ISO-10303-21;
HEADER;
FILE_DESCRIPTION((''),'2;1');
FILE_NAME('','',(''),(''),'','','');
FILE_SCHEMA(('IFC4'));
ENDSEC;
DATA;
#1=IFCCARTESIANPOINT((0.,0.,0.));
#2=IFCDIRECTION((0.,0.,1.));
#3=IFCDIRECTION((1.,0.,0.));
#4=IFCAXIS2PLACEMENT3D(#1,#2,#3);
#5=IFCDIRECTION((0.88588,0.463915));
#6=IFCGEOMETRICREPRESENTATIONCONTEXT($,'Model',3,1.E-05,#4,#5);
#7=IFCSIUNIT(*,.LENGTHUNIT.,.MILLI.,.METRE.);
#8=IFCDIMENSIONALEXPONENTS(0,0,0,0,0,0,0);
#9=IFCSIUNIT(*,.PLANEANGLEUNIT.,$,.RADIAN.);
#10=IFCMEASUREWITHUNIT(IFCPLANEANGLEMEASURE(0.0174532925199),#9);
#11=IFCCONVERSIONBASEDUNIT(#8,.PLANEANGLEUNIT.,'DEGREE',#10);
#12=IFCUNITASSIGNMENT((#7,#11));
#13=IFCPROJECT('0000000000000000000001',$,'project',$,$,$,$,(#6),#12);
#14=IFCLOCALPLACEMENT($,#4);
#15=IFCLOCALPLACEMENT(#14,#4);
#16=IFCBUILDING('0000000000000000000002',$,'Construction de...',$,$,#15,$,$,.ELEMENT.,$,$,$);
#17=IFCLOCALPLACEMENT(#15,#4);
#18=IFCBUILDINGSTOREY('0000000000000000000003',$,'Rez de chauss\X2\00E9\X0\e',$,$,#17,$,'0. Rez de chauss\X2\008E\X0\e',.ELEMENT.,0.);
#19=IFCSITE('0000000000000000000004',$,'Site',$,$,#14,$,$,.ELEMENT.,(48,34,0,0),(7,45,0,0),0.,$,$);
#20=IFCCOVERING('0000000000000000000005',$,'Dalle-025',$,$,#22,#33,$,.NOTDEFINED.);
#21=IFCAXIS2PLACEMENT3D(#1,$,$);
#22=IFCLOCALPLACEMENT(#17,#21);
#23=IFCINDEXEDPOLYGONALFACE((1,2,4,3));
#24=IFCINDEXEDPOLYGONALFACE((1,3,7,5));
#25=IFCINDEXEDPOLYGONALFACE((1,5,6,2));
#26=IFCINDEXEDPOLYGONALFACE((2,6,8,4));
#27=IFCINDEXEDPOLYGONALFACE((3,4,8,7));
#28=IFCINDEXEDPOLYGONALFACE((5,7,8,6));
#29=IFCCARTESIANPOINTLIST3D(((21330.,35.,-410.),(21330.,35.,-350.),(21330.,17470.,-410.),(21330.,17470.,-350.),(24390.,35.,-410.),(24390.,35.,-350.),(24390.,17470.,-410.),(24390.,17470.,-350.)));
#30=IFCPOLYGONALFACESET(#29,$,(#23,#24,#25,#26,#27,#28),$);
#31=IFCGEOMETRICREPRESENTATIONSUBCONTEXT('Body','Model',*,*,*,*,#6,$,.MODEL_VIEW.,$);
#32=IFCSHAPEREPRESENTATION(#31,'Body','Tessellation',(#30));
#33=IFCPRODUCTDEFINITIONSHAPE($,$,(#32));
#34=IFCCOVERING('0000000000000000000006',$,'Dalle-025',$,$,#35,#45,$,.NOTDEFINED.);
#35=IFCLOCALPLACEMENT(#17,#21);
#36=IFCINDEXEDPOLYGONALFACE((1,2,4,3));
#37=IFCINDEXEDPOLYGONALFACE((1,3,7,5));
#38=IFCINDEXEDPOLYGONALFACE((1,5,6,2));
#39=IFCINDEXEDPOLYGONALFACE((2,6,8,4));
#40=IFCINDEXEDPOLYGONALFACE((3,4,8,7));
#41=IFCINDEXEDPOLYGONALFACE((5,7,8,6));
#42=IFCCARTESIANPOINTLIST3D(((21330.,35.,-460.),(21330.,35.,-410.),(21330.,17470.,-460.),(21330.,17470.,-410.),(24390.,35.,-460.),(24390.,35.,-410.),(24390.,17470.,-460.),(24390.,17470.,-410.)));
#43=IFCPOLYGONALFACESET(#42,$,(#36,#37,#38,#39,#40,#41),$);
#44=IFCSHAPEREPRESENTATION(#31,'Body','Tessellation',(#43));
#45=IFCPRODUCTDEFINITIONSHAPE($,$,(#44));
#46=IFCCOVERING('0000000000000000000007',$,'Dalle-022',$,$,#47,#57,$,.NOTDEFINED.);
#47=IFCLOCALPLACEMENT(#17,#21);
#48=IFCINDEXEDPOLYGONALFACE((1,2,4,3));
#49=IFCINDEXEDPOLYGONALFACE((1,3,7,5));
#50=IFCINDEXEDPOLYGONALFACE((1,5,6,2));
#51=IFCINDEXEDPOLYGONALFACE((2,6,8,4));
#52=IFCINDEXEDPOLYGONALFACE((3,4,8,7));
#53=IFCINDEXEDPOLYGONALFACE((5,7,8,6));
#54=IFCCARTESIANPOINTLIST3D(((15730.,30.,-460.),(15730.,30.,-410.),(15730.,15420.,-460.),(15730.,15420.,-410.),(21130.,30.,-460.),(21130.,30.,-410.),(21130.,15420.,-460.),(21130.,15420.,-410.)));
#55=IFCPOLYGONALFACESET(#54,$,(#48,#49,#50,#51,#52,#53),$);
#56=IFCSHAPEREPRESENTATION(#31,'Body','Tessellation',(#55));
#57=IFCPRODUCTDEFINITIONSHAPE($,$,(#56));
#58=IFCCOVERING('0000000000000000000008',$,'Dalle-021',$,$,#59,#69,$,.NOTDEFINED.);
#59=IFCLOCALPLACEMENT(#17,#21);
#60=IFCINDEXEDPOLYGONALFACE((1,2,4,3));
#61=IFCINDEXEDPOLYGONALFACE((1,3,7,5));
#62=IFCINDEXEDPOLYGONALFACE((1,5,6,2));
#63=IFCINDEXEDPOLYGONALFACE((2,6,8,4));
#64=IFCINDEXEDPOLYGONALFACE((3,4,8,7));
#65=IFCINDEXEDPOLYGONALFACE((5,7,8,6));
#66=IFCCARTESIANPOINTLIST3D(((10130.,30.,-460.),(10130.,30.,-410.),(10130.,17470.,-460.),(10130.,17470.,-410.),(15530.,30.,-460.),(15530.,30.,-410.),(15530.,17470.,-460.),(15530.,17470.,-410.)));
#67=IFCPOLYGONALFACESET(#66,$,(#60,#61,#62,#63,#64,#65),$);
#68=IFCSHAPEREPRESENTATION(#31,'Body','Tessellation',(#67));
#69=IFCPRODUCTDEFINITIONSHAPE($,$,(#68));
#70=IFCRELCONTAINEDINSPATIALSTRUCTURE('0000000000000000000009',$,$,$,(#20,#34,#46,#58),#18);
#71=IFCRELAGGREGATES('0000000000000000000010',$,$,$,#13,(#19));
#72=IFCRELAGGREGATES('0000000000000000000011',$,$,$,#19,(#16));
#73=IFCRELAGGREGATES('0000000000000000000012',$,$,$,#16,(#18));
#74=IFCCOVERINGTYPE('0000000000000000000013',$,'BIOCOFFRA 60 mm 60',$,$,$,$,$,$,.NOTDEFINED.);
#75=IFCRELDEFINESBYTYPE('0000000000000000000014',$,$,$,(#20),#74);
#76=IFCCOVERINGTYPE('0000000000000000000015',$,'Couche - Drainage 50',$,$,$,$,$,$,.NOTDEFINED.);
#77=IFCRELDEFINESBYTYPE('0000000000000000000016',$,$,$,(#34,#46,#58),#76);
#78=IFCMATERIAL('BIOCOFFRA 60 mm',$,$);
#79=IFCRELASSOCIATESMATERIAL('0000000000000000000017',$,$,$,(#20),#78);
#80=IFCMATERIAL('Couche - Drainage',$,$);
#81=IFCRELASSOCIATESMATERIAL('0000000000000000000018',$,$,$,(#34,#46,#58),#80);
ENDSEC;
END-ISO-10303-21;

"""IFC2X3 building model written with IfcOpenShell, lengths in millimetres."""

from ifc_helpers import new_model, entity, si_unit, converted_unit, direction, frame, origin_with_axes, place, context, subcontext, project, spatial, polyline, outline, extrude, material, type_object, element, save


model = new_model("IFC2X3")

# Units and contexts
model_context = context("Model", 3, precision=1e-05, world=origin_with_axes(), true_north=direction((0.88588, 0.463915)))
body_context = subcontext(model_context, "Body", "Model", "MODEL_VIEW")
ifc_project = project(units=[si_unit("LENGTHUNIT", "METRE", prefix="MILLI"), converted_unit("PLANEANGLEUNIT", "DEGREE", entity("IfcPlaneAngleMeasure", 0.0174532925199), si_unit("PLANEANGLEUNIT", "RADIAN"), dimensions=[0, 0, 0, 0, 0, 0, 0])], contexts=[model_context])

# Site, building, storey
site_placement = place(None, origin_with_axes())
site = spatial("IfcSite", under=ifc_project, at=site_placement, Name="Site", CompositionType="ELEMENT", RefLatitude=(48, 34, 0, 0), RefLongitude=(7, 45, 0, 0), RefElevation=0.0)
building_placement = place(site_placement, origin_with_axes())
building = spatial("IfcBuilding", under=site, at=building_placement, Name="Construction de...", CompositionType="ELEMENT")
storey_placement = place(building_placement, origin_with_axes())
storey = spatial("IfcBuildingStorey", under=building, at=storey_placement, Name="Rez de chaussée", LongName="0. Rez de chauss\u008ee", CompositionType="ELEMENT", Elevation=0.0)

# Coverings
ifc_material_1 = material(Name="BIOCOFFRA 60 mm")
covering_type_1 = type_object("IfcCoveringType", Name="BIOCOFFRA 60 mm 60", PredefinedType="NOTDEFINED")
covering_1_placement = place(storey_placement, frame((21330.0, 35.0, -350.0), z_axis=(0.0, 0.0, 1.0), x_axis=(1.0, 0.0, 0.0)))
element("IfcCovering", 1, at=covering_1_placement, inside=storey, type_object=covering_type_1, material=ifc_material_1, Name="Dalle-025", PredefinedType="NOTDEFINED", context=body_context, shape_type="SweptSolid", body=[
    extrude(outline(polyline([(0.0, 0.0), (3060.0, 0.0), (3060.0, 17435.0), (0.0, 17435.0), (0.0, 0.0)])), frame((0.0, 0.0, -60.0), z_axis=(0.0, 0.0, 1.0), x_axis=(1.0, 0.0, 0.0)), (0.0, 0.0, 1.0), 60.0),
])
ifc_material_2 = material(Name="Couche - Drainage")
covering_type_2 = type_object("IfcCoveringType", Name="Couche - Drainage 50", PredefinedType="NOTDEFINED")
covering_2_placement = place(storey_placement, frame((21330.0, 35.0, -410.0), z_axis=(0.0, 0.0, 1.0), x_axis=(1.0, 0.0, 0.0)))
element("IfcCovering", 2, at=covering_2_placement, inside=storey, type_object=covering_type_2, material=ifc_material_2, Name="Dalle-025", PredefinedType="NOTDEFINED", context=body_context, shape_type="SweptSolid", body=[
    extrude(outline(polyline([(0.0, 0.0), (3060.0, 0.0), (3060.0, 17435.0), (0.0, 17435.0), (0.0, 0.0)])), frame((0.0, 0.0, -50.0), z_axis=(0.0, 0.0, 1.0), x_axis=(1.0, 0.0, 0.0)), (0.0, 0.0, 1.0), 50.0),
])
covering_3_placement = place(storey_placement, frame((15730.0, 30.0, -410.0), z_axis=(0.0, 0.0, 1.0), x_axis=(1.0, 0.0, 0.0)))
element("IfcCovering", 3, at=covering_3_placement, inside=storey, type_object=covering_type_2, material=ifc_material_2, Name="Dalle-022", PredefinedType="NOTDEFINED", context=body_context, shape_type="SweptSolid", body=[
    extrude(outline(polyline([(0.0, 0.0), (5400.0, 0.0), (5400.0, 15390.0), (0.0, 15390.0), (0.0, 0.0)])), frame((0.0, 0.0, -50.0), z_axis=(0.0, 0.0, 1.0), x_axis=(1.0, 0.0, 0.0)), (0.0, 0.0, 1.0), 50.0),
])
covering_4_placement = place(storey_placement, frame((10130.0, 30.0, -410.0), z_axis=(0.0, 0.0, 1.0), x_axis=(1.0, 0.0, 0.0)))
element("IfcCovering", 4, at=covering_4_placement, inside=storey, type_object=covering_type_2, material=ifc_material_2, Name="Dalle-021", PredefinedType="NOTDEFINED", context=body_context, shape_type="SweptSolid", body=[
    extrude(outline(polyline([(0.0, 0.0), (5400.0, 0.0), (5400.0, 17440.0), (0.0, 17440.0), (0.0, 0.0)])), frame((0.0, 0.0, -50.0), z_axis=(0.0, 0.0, 1.0), x_axis=(1.0, 0.0, 0.0)), (0.0, 0.0, 1.0), 50.0),
])

save(model, "model.ifc")
